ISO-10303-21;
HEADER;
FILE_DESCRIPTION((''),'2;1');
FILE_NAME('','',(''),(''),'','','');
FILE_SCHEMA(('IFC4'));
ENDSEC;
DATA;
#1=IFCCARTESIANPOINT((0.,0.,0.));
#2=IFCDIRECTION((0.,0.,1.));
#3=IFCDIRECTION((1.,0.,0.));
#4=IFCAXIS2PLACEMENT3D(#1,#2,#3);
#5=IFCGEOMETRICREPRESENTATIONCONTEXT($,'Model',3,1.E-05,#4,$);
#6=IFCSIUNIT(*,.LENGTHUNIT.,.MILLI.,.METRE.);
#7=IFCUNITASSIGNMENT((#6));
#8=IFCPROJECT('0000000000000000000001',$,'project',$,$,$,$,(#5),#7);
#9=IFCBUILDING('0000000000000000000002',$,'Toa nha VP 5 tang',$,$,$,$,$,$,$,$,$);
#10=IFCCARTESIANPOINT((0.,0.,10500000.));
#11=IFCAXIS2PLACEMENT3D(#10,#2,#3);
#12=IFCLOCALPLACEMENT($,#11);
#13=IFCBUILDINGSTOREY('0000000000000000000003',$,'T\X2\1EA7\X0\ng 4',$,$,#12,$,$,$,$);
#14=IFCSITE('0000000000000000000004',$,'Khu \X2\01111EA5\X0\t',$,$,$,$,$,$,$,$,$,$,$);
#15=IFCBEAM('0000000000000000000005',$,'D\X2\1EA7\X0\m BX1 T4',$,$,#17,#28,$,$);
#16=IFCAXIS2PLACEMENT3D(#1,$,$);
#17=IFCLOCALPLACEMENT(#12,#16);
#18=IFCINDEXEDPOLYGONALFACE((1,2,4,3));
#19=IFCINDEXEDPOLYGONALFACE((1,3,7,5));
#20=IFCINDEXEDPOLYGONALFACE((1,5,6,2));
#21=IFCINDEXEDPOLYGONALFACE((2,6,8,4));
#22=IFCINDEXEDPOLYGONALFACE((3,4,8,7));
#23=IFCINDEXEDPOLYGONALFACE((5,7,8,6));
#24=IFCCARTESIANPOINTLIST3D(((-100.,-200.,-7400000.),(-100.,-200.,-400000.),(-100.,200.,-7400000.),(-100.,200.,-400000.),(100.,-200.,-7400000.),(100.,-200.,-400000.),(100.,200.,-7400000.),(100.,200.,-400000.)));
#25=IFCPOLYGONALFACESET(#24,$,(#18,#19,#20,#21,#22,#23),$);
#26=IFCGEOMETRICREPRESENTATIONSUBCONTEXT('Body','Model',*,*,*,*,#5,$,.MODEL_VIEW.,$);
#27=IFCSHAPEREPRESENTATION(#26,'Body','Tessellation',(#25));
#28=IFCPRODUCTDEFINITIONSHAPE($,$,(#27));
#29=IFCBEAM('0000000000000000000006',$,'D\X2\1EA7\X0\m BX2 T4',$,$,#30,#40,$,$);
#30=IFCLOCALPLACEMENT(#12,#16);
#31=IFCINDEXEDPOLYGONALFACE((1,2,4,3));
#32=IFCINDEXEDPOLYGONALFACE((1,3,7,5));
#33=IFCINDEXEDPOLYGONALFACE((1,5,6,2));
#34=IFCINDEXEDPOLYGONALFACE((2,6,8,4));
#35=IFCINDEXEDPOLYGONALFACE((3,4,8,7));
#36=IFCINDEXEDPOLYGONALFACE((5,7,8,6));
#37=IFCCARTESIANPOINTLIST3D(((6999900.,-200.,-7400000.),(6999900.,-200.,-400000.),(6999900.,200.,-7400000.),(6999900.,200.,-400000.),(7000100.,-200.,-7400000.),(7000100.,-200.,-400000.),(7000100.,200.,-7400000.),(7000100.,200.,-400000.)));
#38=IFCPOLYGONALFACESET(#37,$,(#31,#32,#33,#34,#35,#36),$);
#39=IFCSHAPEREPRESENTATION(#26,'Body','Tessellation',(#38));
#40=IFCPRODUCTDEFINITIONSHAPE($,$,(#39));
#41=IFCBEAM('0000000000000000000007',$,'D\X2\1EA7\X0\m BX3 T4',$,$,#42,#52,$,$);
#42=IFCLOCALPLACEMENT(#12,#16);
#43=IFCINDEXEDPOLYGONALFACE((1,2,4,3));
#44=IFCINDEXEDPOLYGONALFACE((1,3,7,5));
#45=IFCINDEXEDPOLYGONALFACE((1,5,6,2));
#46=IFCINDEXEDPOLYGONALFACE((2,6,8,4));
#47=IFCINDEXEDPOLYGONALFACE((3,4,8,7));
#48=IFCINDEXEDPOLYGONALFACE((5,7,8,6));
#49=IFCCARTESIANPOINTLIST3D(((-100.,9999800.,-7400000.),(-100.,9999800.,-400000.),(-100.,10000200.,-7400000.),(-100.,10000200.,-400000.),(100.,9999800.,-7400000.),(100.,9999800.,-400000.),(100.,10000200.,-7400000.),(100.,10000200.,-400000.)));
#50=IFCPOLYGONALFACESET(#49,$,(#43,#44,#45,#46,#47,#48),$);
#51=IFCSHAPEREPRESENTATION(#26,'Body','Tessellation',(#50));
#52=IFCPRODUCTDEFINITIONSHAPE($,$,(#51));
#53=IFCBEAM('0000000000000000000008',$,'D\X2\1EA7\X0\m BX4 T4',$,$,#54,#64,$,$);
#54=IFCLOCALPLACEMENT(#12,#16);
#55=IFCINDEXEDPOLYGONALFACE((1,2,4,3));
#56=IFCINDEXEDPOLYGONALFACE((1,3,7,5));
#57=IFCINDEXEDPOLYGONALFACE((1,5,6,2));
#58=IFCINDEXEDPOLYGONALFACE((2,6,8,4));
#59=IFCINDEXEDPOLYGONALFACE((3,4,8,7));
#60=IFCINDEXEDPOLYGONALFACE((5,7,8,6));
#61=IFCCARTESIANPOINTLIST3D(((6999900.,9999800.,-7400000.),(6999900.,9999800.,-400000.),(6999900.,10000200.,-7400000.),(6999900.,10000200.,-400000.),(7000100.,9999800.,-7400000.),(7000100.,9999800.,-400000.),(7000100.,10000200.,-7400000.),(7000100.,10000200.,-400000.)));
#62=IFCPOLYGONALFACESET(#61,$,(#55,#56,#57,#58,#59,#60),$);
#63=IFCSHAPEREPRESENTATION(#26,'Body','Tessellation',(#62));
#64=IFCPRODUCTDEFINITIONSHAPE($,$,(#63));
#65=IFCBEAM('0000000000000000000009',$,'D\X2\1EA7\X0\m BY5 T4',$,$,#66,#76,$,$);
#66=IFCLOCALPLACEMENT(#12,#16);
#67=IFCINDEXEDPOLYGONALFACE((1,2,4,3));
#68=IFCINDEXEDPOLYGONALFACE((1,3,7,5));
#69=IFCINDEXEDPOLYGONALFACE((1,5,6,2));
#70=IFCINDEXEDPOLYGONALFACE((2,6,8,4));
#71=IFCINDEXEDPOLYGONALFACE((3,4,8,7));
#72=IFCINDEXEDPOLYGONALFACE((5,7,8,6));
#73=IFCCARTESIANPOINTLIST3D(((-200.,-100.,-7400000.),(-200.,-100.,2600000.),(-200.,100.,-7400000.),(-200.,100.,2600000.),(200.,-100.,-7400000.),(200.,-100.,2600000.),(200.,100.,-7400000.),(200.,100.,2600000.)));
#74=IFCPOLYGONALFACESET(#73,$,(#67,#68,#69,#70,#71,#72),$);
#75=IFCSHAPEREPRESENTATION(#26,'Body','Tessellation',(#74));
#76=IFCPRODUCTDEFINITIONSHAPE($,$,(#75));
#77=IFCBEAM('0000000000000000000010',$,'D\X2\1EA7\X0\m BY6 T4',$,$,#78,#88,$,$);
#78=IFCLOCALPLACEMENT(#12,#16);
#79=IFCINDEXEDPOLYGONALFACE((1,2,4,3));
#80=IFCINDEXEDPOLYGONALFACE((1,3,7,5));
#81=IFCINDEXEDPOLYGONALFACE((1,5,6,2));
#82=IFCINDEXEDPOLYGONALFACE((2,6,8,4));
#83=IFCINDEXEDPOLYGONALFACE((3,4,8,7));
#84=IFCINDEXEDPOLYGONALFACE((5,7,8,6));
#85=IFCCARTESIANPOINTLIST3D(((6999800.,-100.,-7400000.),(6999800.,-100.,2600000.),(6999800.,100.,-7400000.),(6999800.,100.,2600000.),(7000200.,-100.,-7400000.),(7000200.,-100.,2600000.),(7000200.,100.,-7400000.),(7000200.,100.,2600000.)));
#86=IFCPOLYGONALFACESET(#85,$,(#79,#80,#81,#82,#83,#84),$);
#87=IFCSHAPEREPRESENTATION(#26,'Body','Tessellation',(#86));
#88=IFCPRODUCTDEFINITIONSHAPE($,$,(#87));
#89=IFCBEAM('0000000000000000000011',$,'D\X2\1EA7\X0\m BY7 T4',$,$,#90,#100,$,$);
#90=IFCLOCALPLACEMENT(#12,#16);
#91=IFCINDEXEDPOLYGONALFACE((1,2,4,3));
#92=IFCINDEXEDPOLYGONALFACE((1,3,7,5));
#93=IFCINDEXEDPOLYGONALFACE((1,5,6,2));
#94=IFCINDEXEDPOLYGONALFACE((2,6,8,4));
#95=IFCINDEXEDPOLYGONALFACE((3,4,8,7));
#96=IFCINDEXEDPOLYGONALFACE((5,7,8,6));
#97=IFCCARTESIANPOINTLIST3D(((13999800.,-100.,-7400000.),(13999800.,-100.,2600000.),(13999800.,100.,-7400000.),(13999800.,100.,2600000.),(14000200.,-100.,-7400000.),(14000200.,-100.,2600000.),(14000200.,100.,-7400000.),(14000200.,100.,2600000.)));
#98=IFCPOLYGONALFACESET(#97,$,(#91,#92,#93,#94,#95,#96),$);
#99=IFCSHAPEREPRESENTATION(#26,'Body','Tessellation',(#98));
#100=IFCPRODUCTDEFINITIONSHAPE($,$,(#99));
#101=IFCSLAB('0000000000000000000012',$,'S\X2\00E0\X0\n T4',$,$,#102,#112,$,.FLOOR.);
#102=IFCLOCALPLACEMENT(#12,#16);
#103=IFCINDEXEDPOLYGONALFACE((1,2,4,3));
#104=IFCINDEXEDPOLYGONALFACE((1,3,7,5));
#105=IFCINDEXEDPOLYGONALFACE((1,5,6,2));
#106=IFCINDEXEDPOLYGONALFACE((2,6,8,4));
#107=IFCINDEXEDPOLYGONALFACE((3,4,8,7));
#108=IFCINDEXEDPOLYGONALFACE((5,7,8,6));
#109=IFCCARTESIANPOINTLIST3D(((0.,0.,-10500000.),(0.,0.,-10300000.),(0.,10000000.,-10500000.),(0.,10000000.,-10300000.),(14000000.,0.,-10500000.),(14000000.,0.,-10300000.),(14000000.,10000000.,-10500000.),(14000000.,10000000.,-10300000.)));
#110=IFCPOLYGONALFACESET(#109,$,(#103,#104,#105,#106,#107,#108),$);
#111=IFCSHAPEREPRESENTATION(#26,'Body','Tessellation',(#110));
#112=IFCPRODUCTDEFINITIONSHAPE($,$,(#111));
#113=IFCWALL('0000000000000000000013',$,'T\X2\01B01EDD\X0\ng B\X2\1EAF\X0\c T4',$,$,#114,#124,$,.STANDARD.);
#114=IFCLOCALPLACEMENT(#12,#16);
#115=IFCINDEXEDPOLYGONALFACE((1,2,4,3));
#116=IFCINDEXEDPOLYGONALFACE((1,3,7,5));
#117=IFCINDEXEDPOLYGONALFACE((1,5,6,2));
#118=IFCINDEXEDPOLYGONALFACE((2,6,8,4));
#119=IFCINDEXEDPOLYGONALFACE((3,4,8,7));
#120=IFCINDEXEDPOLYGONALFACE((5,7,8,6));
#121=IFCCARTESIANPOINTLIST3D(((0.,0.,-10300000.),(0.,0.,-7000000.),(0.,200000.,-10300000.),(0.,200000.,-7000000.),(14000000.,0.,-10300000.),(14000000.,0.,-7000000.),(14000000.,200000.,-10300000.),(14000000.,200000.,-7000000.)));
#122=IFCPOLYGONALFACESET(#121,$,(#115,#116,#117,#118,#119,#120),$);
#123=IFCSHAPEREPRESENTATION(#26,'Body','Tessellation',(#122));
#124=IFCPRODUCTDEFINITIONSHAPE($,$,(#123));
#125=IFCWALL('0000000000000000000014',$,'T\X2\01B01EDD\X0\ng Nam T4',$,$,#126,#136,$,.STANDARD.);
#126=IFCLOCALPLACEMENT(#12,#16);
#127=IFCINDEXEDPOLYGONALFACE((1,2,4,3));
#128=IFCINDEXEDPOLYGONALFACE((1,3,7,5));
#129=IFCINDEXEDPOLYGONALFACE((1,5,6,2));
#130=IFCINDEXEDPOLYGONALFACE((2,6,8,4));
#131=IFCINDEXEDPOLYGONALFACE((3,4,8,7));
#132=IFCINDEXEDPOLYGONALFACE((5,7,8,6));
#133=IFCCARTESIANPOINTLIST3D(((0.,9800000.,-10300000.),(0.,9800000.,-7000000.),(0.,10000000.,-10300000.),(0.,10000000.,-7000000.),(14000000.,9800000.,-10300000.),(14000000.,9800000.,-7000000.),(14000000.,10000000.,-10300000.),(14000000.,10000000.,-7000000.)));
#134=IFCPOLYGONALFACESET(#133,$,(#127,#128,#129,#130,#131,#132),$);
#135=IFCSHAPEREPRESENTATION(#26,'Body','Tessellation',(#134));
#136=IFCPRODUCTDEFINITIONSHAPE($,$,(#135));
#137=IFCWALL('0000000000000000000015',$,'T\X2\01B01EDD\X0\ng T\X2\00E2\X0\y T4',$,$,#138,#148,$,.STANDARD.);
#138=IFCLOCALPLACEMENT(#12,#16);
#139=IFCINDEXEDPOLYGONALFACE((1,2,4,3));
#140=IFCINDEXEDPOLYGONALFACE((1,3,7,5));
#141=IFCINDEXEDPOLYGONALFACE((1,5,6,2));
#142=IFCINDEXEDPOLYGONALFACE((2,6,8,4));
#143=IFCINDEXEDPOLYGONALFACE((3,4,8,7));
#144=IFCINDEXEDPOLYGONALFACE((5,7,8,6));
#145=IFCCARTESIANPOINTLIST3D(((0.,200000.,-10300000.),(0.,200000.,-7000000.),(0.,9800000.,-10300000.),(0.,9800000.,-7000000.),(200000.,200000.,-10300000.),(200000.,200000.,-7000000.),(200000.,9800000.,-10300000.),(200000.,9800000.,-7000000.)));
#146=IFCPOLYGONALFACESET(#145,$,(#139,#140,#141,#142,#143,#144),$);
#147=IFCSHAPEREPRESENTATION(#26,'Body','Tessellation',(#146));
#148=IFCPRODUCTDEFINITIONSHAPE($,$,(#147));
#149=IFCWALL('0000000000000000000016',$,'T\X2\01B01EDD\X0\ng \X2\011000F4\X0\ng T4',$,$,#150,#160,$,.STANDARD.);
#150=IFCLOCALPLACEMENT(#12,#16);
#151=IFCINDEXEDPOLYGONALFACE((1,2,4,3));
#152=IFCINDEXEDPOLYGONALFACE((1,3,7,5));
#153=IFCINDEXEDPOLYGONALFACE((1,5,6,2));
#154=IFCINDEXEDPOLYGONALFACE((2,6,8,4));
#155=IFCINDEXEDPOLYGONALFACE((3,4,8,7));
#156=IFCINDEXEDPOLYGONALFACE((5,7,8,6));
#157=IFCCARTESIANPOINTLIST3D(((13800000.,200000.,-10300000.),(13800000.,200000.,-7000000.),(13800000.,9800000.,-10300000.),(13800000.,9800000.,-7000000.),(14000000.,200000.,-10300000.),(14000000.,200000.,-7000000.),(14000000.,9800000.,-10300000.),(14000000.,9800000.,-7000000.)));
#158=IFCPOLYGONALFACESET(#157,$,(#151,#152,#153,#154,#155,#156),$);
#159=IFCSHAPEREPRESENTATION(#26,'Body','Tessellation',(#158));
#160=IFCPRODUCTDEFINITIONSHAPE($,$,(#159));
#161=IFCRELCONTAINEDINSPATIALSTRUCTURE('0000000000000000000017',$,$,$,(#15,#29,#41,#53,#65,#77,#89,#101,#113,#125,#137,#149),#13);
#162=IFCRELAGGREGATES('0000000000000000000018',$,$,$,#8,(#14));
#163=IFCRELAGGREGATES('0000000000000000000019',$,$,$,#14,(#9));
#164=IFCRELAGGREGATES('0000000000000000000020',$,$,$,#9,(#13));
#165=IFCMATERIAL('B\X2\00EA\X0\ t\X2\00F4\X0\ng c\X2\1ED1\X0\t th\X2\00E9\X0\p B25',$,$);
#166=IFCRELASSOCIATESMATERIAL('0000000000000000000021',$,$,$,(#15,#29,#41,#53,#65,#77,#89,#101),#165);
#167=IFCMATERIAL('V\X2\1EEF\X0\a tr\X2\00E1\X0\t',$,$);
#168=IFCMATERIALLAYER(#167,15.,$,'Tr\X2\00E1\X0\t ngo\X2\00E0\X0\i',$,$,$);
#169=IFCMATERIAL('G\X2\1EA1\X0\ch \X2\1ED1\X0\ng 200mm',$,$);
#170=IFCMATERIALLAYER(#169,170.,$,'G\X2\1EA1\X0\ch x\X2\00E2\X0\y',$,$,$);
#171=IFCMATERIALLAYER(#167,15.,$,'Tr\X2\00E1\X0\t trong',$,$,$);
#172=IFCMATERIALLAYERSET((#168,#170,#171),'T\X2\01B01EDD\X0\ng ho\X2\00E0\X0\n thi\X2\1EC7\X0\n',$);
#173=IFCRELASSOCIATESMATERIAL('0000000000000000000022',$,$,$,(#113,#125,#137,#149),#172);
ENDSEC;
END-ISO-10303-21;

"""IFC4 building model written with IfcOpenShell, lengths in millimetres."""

from ifc_helpers import new_model, entity, si_unit, frame, origin_with_axes, place, context, subcontext, project, spatial, indexed_curve, outline, extrude, material, layer, layer_set, layer_usage, element, save


model = new_model("IFC4")

# Units and contexts
model_context = context("Model", 3, precision=1e-05, world=origin_with_axes())
body_context = subcontext(model_context, "Body", "Model", "MODEL_VIEW")
ifc_project = project(units=[si_unit("LENGTHUNIT", "METRE", prefix="MILLI")], contexts=[model_context])

# Site, building, storey
site = spatial("IfcSite", under=ifc_project, Name="Khu đất")
building = spatial("IfcBuilding", under=site, Name="Toa nha VP 5 tang")
storey_placement = place(None, frame((0.0, 0.0, 10500000.0), z_axis=(0.0, 0.0, 1.0), x_axis=(1.0, 0.0, 0.0)))
storey = spatial("IfcBuildingStorey", under=building, at=storey_placement, Name="Tầng 4")

# Beams
ifc_material_1 = material(Name="Bê tông cốt thép B25")
for number, where, z_axis, x_axis, name in (
    (1, (0.0, 0.0, -7400000.0), (0.0, 0.0, 1.0), (1.0, 0.0, 0.0), "Dầm BX1 T4"),
    (2, (7000000.0, 0.0, -7400000.0), (0.0, 0.0, 1.0), (1.0, 0.0, 0.0), "Dầm BX2 T4"),
    (3, (0.0, 10000000.0, -7400000.0), (0.0, 0.0, 1.0), (1.0, 0.0, 0.0), "Dầm BX3 T4"),
    (4, (7000000.0, 10000000.0, -7400000.0), (0.0, 0.0, 1.0), (1.0, 0.0, 0.0), "Dầm BX4 T4"),
):
    element("IfcBeam", number, at=place(storey_placement, frame(where, z_axis=z_axis, x_axis=x_axis)), inside=storey, material=ifc_material_1, Name=name, context=body_context, shape_type="SweptSolid", body=[
        extrude(entity("IfcRectangleProfileDef", None, None, None, 200.0, 400.0), origin_with_axes(), (0.0, 0.0, 1.0), 7000000.0),
    ])
for number, where, z_axis, x_axis, name in (
    (5, (0.0, 0.0, -7400000.0), (0.0, 0.0, 1.0), (0.0, 1.0, 0.0), "Dầm BY5 T4"),
    (6, (7000000.0, 0.0, -7400000.0), (0.0, 0.0, 1.0), (0.0, 1.0, 0.0), "Dầm BY6 T4"),
    (7, (14000000.0, 0.0, -7400000.0), (0.0, 0.0, 1.0), (0.0, 1.0, 0.0), "Dầm BY7 T4"),
):
    element("IfcBeam", number, at=place(storey_placement, frame(where, z_axis=z_axis, x_axis=x_axis)), inside=storey, material=ifc_material_1, Name=name, context=body_context, shape_type="SweptSolid", body=[
        extrude(entity("IfcRectangleProfileDef", None, None, None, 200.0, 400.0), origin_with_axes(), (0.0, 0.0, 1.0), 10000000.0),
    ])

# Slab
slab_placement = place(storey_placement, frame((0.0, 0.0, -10500000.0), z_axis=(0.0, 0.0, 1.0), x_axis=(1.0, 0.0, 0.0)))
element("IfcSlab", 8, at=slab_placement, inside=storey, material=ifc_material_1, Name="Sàn T4", PredefinedType="FLOOR", context=body_context, shape_type="SweptSolid", body=[
    extrude(outline(indexed_curve([(0.0, 0.0), (14000000.0, 0.0), (14000000.0, 10000000.0), (0.0, 10000000.0), (0.0, 0.0)])), None, (0.0, 0.0, 1.0), 200000.0),
])

# Walls
ifc_material_2 = material(Name="Vữa trát")
ifc_layer_1 = layer(ifc_material_2, 15.0, Name="Trát ngoài")
ifc_material_3 = material(Name="Gạch ống 200mm")
ifc_layer_2 = layer(ifc_material_3, 170.0, Name="Gạch xây")
ifc_layer_3 = layer(ifc_material_2, 15.0, Name="Trát trong")
ifc_layer_set = layer_set([ifc_layer_1, ifc_layer_2, ifc_layer_3], Name="Tường hoàn thiện")
ifc_layer_usage_1 = layer_usage(ifc_layer_set, "AXIS2", "POSITIVE", 0.0)
wall_1_placement = place(storey_placement, frame((0.0, 0.0, -10300000.0), z_axis=(0.0, 0.0, 1.0), x_axis=(1.0, 0.0, 0.0)))
element("IfcWall", 9, at=wall_1_placement, inside=storey, material=ifc_layer_usage_1, Name="Tường Bắc T4", PredefinedType="STANDARD", context=body_context, shape_type="SweptSolid", body=[
    extrude(outline(indexed_curve([(0.0, 0.0), (0.0, 200000.0), (14000000.0, 200000.0), (14000000.0, 0.0), (0.0, 0.0)], self_intersect=False)), origin_with_axes(), (0.0, 0.0, 1.0), 3300000.0),
])
ifc_layer_usage_2 = layer_usage(ifc_layer_set, "AXIS2", "POSITIVE", 0.0)
wall_2_placement = place(storey_placement, frame((0.0, 9800000.0, -10300000.0), z_axis=(0.0, 0.0, 1.0), x_axis=(1.0, 0.0, 0.0)))
element("IfcWall", 10, at=wall_2_placement, inside=storey, material=ifc_layer_usage_2, Name="Tường Nam T4", PredefinedType="STANDARD", context=body_context, shape_type="SweptSolid", body=[
    extrude(outline(indexed_curve([(0.0, 0.0), (0.0, 200000.0), (14000000.0, 200000.0), (14000000.0, 0.0), (0.0, 0.0)], self_intersect=False)), origin_with_axes(), (0.0, 0.0, 1.0), 3300000.0),
])
ifc_layer_usage_3 = layer_usage(ifc_layer_set, "AXIS2", "POSITIVE", 0.0)
wall_3_placement = place(storey_placement, frame((0.0, 200000.0, -10300000.0), z_axis=(0.0, 0.0, 1.0), x_axis=(1.0, 0.0, 0.0)))
element("IfcWall", 11, at=wall_3_placement, inside=storey, material=ifc_layer_usage_3, Name="Tường Tây T4", PredefinedType="STANDARD", context=body_context, shape_type="SweptSolid", body=[
    extrude(outline(indexed_curve([(0.0, 0.0), (0.0, 9600000.0), (200000.0, 9600000.0), (200000.0, 0.0), (0.0, 0.0)], self_intersect=False)), origin_with_axes(), (0.0, 0.0, 1.0), 3300000.0),
])
ifc_layer_usage_4 = layer_usage(ifc_layer_set, "AXIS2", "POSITIVE", 0.0)
wall_4_placement = place(storey_placement, frame((13800000.0, 200000.0, -10300000.0), z_axis=(0.0, 0.0, 1.0), x_axis=(1.0, 0.0, 0.0)))
element("IfcWall", 12, at=wall_4_placement, inside=storey, material=ifc_layer_usage_4, Name="Tường Đông T4", PredefinedType="STANDARD", context=body_context, shape_type="SweptSolid", body=[
    extrude(outline(indexed_curve([(0.0, 0.0), (0.0, 9600000.0), (200000.0, 9600000.0), (200000.0, 0.0), (0.0, 0.0)], self_intersect=False)), origin_with_axes(), (0.0, 0.0, 1.0), 3300000.0),
])

save(model, "model.ifc")
